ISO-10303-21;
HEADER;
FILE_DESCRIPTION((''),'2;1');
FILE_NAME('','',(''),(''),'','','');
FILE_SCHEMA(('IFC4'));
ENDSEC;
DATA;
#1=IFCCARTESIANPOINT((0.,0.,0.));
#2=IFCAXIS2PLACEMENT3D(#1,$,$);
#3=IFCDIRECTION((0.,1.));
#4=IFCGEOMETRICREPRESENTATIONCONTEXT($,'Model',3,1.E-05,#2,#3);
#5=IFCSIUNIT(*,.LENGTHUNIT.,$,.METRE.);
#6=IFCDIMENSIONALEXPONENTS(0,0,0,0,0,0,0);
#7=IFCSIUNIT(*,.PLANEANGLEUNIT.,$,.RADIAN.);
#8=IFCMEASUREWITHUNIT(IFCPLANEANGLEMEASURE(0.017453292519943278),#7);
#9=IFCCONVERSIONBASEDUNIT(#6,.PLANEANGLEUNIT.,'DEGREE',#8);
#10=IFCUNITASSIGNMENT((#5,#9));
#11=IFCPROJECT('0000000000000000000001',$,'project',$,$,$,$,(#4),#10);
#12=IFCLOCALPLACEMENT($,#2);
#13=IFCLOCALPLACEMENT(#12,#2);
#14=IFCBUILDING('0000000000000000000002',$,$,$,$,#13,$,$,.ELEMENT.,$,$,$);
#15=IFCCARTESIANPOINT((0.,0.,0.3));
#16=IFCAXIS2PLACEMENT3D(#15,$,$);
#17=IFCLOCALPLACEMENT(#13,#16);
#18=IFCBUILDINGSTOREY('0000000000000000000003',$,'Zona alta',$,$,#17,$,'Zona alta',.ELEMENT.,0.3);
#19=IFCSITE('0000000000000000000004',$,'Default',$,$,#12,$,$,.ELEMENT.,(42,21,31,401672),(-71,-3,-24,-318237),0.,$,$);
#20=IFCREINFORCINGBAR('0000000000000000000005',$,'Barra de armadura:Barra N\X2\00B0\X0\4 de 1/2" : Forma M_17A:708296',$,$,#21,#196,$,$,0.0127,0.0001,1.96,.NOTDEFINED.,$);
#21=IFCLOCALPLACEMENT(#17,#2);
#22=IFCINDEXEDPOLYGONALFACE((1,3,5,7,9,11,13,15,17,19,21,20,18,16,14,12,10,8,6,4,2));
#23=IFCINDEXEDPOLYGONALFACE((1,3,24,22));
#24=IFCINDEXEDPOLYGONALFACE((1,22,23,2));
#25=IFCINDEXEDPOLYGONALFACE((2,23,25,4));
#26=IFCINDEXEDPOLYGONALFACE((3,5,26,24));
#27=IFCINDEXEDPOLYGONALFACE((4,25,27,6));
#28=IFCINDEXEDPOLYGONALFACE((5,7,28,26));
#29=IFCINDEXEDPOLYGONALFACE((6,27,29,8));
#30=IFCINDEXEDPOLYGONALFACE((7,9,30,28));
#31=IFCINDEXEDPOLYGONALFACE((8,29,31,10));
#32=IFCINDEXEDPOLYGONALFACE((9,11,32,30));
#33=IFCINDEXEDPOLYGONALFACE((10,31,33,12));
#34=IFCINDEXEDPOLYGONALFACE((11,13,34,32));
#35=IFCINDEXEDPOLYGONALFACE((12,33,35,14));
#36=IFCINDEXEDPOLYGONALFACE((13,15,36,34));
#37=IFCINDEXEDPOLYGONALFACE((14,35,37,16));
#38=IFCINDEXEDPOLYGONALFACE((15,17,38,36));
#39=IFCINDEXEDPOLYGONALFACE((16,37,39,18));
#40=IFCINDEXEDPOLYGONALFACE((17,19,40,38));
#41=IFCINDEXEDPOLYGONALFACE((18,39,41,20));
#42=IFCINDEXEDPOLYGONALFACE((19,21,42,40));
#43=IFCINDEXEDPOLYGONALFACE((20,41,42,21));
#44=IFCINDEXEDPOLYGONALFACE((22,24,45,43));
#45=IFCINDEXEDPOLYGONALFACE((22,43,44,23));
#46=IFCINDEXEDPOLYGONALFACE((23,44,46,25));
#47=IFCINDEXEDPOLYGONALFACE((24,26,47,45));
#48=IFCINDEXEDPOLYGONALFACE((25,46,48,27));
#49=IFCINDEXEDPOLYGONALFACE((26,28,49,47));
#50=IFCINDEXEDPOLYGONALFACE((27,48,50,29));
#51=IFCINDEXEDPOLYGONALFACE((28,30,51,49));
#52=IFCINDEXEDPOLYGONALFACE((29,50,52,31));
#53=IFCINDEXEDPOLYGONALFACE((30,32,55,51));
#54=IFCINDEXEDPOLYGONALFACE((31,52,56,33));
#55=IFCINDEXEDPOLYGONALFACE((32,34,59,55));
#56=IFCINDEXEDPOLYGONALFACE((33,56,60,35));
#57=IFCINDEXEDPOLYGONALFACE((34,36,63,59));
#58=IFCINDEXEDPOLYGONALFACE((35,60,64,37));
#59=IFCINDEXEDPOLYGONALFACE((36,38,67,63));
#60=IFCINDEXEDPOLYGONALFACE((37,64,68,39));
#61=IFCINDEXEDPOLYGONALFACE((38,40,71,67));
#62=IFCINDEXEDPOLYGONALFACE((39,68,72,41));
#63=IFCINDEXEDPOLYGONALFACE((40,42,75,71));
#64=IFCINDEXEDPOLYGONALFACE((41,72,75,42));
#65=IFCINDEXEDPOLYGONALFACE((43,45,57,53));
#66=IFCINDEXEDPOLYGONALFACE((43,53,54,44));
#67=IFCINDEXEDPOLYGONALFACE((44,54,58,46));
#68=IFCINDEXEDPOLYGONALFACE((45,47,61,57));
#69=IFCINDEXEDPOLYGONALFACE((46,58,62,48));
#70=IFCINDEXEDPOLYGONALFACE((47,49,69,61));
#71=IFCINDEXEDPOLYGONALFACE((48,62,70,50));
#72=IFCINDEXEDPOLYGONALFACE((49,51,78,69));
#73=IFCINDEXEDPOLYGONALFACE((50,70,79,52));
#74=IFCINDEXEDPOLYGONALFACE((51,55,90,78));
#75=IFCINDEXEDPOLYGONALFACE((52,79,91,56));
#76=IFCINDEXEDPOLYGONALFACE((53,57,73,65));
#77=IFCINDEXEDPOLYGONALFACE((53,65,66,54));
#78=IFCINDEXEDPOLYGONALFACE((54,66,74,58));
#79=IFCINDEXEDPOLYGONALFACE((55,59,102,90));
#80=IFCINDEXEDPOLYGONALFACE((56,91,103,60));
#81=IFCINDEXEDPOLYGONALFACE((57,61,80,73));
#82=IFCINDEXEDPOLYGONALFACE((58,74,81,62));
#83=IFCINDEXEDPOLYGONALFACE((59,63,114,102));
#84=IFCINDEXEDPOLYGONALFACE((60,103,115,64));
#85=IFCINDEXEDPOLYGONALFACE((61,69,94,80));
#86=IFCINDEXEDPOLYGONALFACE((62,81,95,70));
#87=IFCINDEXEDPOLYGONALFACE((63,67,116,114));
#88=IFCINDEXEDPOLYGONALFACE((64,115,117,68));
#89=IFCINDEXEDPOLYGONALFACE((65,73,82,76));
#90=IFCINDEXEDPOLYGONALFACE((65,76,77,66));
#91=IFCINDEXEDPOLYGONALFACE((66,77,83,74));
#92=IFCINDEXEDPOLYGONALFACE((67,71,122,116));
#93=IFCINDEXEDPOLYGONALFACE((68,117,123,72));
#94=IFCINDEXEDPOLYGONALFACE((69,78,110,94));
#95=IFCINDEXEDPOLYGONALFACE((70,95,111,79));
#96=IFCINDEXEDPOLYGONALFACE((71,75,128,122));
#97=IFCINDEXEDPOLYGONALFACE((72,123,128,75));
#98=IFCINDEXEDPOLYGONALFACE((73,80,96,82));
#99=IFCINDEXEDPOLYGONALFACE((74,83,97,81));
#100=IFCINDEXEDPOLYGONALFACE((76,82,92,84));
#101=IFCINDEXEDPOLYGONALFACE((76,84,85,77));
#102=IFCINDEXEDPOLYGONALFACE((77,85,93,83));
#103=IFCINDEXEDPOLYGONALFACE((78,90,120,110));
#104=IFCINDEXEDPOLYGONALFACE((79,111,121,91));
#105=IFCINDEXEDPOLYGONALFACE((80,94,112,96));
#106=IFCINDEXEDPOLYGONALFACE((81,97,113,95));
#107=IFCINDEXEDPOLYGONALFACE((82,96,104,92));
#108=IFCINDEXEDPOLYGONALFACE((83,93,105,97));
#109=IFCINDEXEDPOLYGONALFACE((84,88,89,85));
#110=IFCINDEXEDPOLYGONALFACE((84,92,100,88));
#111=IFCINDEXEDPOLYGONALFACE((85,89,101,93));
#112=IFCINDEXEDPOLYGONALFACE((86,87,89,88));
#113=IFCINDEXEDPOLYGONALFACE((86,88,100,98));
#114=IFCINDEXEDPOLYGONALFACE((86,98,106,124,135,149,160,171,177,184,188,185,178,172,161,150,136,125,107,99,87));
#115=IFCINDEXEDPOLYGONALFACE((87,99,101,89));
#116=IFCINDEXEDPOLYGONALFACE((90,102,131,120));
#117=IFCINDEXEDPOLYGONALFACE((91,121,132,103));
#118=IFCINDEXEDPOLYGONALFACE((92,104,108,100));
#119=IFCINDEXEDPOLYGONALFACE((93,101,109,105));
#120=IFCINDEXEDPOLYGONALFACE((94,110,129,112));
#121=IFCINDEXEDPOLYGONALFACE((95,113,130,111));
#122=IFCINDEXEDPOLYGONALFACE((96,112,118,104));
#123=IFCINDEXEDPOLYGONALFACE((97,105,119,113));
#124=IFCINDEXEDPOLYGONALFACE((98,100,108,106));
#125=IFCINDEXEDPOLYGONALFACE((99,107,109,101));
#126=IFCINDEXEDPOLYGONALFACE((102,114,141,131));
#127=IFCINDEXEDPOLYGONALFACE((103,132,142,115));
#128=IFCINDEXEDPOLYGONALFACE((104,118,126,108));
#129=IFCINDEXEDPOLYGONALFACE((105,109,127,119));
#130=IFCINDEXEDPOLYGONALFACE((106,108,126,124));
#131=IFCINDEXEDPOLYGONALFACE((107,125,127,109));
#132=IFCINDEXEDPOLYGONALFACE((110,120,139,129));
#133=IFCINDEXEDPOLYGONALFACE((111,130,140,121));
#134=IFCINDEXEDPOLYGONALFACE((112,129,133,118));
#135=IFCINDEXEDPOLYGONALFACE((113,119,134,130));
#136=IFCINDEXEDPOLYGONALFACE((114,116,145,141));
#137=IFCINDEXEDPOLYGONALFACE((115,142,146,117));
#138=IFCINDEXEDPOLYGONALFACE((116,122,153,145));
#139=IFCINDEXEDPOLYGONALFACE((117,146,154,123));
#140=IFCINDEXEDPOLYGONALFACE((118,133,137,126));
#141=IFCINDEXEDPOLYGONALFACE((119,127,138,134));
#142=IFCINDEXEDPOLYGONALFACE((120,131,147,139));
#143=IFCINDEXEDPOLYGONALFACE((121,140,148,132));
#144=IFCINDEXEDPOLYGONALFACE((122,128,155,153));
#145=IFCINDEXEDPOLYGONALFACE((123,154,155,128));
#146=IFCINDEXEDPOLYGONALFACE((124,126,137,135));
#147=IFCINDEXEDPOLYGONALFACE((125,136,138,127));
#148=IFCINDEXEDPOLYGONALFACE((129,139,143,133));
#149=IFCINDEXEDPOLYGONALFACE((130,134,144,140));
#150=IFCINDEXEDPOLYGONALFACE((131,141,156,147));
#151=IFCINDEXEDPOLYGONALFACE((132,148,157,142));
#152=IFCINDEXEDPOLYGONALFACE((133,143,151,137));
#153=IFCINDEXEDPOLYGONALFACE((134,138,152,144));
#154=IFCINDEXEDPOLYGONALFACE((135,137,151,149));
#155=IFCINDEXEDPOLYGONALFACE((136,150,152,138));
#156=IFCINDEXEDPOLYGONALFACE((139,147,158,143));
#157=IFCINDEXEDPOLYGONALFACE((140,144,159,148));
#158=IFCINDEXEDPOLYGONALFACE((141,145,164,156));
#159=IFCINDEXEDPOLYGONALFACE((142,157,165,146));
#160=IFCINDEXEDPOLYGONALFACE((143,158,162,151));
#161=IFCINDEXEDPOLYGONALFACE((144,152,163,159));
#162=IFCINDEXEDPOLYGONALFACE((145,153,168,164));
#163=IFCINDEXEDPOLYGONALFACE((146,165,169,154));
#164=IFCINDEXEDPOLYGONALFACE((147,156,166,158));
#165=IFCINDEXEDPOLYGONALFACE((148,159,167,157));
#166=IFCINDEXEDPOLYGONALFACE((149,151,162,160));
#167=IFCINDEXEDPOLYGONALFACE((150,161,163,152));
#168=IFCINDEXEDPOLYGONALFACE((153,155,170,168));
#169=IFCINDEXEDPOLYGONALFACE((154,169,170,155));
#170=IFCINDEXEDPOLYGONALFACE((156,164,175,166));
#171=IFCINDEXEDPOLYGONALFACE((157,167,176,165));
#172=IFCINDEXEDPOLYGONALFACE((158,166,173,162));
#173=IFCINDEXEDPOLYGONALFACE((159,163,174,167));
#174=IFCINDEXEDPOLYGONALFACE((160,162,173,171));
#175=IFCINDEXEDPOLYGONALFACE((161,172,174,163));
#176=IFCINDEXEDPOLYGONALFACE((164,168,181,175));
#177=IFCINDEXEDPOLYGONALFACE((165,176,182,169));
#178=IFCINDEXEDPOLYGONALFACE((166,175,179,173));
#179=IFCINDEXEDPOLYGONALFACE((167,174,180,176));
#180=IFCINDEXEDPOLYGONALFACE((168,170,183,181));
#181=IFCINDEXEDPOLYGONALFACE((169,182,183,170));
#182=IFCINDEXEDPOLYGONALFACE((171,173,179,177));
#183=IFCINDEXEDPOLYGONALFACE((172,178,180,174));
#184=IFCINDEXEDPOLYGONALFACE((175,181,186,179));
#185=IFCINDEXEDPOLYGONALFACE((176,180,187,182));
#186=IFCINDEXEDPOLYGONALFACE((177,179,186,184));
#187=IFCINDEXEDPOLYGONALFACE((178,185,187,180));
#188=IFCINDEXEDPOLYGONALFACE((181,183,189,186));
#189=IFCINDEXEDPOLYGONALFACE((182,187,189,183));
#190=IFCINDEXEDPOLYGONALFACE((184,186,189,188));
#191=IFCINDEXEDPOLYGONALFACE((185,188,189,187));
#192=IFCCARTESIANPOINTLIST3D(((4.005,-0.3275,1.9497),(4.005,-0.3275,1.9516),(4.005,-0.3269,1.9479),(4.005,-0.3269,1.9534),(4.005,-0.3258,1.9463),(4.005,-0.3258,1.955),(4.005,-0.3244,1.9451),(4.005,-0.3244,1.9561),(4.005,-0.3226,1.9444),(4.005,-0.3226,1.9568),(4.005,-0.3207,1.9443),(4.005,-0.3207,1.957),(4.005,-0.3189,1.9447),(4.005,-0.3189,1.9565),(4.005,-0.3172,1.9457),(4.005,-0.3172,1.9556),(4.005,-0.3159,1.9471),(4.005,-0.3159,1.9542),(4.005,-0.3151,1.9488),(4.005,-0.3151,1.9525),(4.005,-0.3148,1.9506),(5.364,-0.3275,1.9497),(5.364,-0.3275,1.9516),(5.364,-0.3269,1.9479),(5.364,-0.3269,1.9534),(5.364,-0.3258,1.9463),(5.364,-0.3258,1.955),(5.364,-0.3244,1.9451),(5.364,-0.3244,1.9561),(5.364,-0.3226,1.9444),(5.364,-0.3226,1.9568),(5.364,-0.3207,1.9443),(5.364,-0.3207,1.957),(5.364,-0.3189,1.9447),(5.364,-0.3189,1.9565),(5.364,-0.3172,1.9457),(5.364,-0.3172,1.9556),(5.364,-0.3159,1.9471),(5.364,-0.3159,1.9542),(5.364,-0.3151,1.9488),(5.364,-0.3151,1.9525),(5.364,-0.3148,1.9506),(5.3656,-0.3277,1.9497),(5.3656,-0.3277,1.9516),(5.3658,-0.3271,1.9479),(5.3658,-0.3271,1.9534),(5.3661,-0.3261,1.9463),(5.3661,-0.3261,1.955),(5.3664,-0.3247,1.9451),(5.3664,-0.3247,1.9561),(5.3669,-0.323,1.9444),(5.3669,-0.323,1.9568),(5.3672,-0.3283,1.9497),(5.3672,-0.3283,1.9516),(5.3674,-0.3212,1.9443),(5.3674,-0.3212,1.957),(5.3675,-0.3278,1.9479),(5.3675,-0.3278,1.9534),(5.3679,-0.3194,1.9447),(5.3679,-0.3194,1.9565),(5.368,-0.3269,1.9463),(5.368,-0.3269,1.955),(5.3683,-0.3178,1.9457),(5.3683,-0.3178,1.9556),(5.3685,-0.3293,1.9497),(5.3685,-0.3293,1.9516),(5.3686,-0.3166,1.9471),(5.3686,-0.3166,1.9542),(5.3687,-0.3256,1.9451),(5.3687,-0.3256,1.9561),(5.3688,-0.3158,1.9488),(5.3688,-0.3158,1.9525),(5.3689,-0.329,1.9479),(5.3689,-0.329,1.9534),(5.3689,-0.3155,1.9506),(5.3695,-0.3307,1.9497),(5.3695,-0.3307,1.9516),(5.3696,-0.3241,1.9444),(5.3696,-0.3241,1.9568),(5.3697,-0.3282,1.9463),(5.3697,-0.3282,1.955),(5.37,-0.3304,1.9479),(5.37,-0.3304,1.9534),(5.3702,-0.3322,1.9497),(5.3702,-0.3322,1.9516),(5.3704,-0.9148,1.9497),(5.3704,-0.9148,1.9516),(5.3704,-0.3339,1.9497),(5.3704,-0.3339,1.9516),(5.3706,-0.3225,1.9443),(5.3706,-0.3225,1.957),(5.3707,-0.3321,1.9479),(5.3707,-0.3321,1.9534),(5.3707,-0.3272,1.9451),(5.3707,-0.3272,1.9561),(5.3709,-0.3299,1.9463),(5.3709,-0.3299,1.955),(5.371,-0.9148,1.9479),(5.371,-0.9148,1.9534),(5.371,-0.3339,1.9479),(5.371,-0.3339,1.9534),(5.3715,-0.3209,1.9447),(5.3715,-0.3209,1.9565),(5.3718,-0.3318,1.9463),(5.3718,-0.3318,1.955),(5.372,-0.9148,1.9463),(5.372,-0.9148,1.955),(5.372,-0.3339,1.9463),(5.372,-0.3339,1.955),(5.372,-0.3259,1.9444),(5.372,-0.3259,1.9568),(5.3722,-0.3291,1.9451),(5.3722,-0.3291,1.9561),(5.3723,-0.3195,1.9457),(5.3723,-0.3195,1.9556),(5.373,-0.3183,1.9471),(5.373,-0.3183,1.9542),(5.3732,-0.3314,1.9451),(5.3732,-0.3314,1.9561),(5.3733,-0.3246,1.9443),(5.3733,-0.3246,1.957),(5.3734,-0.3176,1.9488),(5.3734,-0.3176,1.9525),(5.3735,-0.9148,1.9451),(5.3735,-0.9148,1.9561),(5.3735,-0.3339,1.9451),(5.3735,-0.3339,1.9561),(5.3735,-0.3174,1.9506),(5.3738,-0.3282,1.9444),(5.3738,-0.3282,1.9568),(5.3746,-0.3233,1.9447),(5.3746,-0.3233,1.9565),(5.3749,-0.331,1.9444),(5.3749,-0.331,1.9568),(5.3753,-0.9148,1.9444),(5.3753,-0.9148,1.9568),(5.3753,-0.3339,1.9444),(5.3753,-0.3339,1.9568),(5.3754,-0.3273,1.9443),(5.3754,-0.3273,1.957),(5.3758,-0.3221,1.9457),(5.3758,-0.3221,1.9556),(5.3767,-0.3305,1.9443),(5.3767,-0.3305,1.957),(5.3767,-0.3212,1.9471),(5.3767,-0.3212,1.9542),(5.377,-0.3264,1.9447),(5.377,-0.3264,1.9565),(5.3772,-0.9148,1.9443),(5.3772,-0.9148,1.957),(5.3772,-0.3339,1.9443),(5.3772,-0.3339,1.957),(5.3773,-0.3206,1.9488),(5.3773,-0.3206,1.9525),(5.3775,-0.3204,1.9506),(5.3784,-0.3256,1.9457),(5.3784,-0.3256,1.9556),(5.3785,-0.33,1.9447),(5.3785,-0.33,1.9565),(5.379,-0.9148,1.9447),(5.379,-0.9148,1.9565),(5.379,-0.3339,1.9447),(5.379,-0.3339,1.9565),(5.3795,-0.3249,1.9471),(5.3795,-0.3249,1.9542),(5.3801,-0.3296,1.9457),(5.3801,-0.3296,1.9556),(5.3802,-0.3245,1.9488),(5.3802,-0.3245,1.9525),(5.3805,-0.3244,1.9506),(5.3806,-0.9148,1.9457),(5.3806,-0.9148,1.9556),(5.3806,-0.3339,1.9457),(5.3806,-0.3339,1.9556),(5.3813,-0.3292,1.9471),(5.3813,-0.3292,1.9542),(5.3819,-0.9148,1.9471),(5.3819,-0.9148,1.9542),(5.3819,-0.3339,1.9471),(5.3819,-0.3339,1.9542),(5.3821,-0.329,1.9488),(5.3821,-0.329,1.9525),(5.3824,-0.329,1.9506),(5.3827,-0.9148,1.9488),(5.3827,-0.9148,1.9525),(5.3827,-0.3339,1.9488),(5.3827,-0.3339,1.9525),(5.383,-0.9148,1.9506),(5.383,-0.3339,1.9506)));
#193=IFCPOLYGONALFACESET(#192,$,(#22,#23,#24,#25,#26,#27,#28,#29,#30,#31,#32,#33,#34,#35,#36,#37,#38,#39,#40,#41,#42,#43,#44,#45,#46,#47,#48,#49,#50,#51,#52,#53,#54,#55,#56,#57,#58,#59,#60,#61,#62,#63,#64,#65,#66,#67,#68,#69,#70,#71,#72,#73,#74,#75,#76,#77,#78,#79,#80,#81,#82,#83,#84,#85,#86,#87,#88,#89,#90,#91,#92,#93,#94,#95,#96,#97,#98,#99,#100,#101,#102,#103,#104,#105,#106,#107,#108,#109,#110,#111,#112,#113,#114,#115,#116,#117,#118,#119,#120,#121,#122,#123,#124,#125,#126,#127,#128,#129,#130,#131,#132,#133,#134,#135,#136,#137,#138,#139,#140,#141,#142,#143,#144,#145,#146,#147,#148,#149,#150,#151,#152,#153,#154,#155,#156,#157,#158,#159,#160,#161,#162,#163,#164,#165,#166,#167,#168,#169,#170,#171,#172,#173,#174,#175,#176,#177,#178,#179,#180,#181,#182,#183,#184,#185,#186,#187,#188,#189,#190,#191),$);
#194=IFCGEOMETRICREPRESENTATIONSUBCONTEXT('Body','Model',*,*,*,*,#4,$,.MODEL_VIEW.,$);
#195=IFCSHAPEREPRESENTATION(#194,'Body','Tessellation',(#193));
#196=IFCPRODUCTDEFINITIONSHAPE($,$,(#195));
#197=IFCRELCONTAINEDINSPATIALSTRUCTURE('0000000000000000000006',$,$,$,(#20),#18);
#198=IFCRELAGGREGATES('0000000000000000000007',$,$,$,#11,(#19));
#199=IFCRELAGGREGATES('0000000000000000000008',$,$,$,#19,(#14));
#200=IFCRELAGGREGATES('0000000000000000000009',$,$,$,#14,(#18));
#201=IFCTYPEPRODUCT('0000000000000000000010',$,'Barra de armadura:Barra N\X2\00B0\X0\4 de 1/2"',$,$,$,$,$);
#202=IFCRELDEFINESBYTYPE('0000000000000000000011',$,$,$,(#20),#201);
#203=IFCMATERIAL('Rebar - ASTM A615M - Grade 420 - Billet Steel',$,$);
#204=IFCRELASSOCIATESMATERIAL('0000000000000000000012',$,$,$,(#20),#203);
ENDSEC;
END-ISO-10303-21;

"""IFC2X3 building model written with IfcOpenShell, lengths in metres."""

from ifc_helpers import new_model, entity, si_unit, converted_unit, direction, frame, origin, place, context, subcontext, project, spatial, material, type_object, element, save


model = new_model("IFC2X3")

# Units and contexts
model_context = context("Model", 3, precision=1e-05, world=origin(), true_north=direction((0.0, 1.0)))
body_context = subcontext(model_context, "Body", "Model", "MODEL_VIEW")
ifc_project = project(units=[si_unit("LENGTHUNIT", "METRE"), converted_unit("PLANEANGLEUNIT", "DEGREE", entity("IfcPlaneAngleMeasure", 0.017453292519943278), si_unit("PLANEANGLEUNIT", "RADIAN"), dimensions=[0, 0, 0, 0, 0, 0, 0])], contexts=[model_context])

# Site, building, storey
site_placement = place(None, origin())
site = spatial("IfcSite", under=ifc_project, at=site_placement, Name="Default", CompositionType="ELEMENT", RefLatitude=(42, 21, 31, 401672), RefLongitude=(-71, -3, -24, -318237), RefElevation=0.0)
building_placement = place(site_placement, origin())
building = spatial("IfcBuilding", under=site, at=building_placement, CompositionType="ELEMENT")
storey_placement = place(building_placement, frame((0.0, 0.0, 0.3)))
storey = spatial("IfcBuildingStorey", under=building, at=storey_placement, Name="Zona alta", LongName="Zona alta", CompositionType="ELEMENT", Elevation=0.3)

# Reinforcing bar
ifc_material = material(Name="Rebar - ASTM A615M - Grade 420 - Billet Steel")
type_product_1 = type_object("IfcTypeProduct", Name="Barra de armadura:Barra N°4 de 1/2\"")
reinforcing_bar_1_placement = place(storey_placement, origin())
element("IfcReinforcingBar", 1, at=reinforcing_bar_1_placement, inside=storey, type_object=type_product_1, material=ifc_material, Name="Barra de armadura:Barra N°4 de 1/2\" : Forma M_17A:708296", BarLength=1.96, BarRole="NOTDEFINED", CrossSectionArea=0.0001, NominalDiameter=0.0127, context=body_context, shape_type="AdvancedSweptSolid", body=[
    entity("IfcSweptDiskSolid", entity("IfcCompositeCurve", [entity("IfcCompositeCurveSegment", "CONTINUOUS", True, entity("IfcPolyline", [entity("IfcCartesianPoint", [4.005, -0.3212, 1.9506]), entity("IfcCartesianPoint", [5.364, -0.3212, 1.9506])])), entity("IfcCompositeCurveSegment", "CONTINUOUS", True, entity("IfcTrimmedCurve", entity("IfcCircle", entity("IfcAxis2Placement3D", entity("IfcCartesianPoint", [5.364, -0.3339, 1.9506]), entity("IfcDirection", [0.0, 0.0, -1.0]), entity("IfcDirection", [1.0, 0.0, 0.0])), 0.0127), [entity("IfcParameterValue", 270.0)], [entity("IfcParameterValue", 360.0)], True, "PARAMETER")), entity("IfcCompositeCurveSegment", "CONTINUOUS", True, entity("IfcPolyline", [entity("IfcCartesianPoint", [5.3767, -0.3339, 1.9506]), entity("IfcCartesianPoint", [5.3767, -0.9148, 1.9506])]))], False), 0.0063, None, 0.0, 92.0),
])

save(model, "model.ifc")
